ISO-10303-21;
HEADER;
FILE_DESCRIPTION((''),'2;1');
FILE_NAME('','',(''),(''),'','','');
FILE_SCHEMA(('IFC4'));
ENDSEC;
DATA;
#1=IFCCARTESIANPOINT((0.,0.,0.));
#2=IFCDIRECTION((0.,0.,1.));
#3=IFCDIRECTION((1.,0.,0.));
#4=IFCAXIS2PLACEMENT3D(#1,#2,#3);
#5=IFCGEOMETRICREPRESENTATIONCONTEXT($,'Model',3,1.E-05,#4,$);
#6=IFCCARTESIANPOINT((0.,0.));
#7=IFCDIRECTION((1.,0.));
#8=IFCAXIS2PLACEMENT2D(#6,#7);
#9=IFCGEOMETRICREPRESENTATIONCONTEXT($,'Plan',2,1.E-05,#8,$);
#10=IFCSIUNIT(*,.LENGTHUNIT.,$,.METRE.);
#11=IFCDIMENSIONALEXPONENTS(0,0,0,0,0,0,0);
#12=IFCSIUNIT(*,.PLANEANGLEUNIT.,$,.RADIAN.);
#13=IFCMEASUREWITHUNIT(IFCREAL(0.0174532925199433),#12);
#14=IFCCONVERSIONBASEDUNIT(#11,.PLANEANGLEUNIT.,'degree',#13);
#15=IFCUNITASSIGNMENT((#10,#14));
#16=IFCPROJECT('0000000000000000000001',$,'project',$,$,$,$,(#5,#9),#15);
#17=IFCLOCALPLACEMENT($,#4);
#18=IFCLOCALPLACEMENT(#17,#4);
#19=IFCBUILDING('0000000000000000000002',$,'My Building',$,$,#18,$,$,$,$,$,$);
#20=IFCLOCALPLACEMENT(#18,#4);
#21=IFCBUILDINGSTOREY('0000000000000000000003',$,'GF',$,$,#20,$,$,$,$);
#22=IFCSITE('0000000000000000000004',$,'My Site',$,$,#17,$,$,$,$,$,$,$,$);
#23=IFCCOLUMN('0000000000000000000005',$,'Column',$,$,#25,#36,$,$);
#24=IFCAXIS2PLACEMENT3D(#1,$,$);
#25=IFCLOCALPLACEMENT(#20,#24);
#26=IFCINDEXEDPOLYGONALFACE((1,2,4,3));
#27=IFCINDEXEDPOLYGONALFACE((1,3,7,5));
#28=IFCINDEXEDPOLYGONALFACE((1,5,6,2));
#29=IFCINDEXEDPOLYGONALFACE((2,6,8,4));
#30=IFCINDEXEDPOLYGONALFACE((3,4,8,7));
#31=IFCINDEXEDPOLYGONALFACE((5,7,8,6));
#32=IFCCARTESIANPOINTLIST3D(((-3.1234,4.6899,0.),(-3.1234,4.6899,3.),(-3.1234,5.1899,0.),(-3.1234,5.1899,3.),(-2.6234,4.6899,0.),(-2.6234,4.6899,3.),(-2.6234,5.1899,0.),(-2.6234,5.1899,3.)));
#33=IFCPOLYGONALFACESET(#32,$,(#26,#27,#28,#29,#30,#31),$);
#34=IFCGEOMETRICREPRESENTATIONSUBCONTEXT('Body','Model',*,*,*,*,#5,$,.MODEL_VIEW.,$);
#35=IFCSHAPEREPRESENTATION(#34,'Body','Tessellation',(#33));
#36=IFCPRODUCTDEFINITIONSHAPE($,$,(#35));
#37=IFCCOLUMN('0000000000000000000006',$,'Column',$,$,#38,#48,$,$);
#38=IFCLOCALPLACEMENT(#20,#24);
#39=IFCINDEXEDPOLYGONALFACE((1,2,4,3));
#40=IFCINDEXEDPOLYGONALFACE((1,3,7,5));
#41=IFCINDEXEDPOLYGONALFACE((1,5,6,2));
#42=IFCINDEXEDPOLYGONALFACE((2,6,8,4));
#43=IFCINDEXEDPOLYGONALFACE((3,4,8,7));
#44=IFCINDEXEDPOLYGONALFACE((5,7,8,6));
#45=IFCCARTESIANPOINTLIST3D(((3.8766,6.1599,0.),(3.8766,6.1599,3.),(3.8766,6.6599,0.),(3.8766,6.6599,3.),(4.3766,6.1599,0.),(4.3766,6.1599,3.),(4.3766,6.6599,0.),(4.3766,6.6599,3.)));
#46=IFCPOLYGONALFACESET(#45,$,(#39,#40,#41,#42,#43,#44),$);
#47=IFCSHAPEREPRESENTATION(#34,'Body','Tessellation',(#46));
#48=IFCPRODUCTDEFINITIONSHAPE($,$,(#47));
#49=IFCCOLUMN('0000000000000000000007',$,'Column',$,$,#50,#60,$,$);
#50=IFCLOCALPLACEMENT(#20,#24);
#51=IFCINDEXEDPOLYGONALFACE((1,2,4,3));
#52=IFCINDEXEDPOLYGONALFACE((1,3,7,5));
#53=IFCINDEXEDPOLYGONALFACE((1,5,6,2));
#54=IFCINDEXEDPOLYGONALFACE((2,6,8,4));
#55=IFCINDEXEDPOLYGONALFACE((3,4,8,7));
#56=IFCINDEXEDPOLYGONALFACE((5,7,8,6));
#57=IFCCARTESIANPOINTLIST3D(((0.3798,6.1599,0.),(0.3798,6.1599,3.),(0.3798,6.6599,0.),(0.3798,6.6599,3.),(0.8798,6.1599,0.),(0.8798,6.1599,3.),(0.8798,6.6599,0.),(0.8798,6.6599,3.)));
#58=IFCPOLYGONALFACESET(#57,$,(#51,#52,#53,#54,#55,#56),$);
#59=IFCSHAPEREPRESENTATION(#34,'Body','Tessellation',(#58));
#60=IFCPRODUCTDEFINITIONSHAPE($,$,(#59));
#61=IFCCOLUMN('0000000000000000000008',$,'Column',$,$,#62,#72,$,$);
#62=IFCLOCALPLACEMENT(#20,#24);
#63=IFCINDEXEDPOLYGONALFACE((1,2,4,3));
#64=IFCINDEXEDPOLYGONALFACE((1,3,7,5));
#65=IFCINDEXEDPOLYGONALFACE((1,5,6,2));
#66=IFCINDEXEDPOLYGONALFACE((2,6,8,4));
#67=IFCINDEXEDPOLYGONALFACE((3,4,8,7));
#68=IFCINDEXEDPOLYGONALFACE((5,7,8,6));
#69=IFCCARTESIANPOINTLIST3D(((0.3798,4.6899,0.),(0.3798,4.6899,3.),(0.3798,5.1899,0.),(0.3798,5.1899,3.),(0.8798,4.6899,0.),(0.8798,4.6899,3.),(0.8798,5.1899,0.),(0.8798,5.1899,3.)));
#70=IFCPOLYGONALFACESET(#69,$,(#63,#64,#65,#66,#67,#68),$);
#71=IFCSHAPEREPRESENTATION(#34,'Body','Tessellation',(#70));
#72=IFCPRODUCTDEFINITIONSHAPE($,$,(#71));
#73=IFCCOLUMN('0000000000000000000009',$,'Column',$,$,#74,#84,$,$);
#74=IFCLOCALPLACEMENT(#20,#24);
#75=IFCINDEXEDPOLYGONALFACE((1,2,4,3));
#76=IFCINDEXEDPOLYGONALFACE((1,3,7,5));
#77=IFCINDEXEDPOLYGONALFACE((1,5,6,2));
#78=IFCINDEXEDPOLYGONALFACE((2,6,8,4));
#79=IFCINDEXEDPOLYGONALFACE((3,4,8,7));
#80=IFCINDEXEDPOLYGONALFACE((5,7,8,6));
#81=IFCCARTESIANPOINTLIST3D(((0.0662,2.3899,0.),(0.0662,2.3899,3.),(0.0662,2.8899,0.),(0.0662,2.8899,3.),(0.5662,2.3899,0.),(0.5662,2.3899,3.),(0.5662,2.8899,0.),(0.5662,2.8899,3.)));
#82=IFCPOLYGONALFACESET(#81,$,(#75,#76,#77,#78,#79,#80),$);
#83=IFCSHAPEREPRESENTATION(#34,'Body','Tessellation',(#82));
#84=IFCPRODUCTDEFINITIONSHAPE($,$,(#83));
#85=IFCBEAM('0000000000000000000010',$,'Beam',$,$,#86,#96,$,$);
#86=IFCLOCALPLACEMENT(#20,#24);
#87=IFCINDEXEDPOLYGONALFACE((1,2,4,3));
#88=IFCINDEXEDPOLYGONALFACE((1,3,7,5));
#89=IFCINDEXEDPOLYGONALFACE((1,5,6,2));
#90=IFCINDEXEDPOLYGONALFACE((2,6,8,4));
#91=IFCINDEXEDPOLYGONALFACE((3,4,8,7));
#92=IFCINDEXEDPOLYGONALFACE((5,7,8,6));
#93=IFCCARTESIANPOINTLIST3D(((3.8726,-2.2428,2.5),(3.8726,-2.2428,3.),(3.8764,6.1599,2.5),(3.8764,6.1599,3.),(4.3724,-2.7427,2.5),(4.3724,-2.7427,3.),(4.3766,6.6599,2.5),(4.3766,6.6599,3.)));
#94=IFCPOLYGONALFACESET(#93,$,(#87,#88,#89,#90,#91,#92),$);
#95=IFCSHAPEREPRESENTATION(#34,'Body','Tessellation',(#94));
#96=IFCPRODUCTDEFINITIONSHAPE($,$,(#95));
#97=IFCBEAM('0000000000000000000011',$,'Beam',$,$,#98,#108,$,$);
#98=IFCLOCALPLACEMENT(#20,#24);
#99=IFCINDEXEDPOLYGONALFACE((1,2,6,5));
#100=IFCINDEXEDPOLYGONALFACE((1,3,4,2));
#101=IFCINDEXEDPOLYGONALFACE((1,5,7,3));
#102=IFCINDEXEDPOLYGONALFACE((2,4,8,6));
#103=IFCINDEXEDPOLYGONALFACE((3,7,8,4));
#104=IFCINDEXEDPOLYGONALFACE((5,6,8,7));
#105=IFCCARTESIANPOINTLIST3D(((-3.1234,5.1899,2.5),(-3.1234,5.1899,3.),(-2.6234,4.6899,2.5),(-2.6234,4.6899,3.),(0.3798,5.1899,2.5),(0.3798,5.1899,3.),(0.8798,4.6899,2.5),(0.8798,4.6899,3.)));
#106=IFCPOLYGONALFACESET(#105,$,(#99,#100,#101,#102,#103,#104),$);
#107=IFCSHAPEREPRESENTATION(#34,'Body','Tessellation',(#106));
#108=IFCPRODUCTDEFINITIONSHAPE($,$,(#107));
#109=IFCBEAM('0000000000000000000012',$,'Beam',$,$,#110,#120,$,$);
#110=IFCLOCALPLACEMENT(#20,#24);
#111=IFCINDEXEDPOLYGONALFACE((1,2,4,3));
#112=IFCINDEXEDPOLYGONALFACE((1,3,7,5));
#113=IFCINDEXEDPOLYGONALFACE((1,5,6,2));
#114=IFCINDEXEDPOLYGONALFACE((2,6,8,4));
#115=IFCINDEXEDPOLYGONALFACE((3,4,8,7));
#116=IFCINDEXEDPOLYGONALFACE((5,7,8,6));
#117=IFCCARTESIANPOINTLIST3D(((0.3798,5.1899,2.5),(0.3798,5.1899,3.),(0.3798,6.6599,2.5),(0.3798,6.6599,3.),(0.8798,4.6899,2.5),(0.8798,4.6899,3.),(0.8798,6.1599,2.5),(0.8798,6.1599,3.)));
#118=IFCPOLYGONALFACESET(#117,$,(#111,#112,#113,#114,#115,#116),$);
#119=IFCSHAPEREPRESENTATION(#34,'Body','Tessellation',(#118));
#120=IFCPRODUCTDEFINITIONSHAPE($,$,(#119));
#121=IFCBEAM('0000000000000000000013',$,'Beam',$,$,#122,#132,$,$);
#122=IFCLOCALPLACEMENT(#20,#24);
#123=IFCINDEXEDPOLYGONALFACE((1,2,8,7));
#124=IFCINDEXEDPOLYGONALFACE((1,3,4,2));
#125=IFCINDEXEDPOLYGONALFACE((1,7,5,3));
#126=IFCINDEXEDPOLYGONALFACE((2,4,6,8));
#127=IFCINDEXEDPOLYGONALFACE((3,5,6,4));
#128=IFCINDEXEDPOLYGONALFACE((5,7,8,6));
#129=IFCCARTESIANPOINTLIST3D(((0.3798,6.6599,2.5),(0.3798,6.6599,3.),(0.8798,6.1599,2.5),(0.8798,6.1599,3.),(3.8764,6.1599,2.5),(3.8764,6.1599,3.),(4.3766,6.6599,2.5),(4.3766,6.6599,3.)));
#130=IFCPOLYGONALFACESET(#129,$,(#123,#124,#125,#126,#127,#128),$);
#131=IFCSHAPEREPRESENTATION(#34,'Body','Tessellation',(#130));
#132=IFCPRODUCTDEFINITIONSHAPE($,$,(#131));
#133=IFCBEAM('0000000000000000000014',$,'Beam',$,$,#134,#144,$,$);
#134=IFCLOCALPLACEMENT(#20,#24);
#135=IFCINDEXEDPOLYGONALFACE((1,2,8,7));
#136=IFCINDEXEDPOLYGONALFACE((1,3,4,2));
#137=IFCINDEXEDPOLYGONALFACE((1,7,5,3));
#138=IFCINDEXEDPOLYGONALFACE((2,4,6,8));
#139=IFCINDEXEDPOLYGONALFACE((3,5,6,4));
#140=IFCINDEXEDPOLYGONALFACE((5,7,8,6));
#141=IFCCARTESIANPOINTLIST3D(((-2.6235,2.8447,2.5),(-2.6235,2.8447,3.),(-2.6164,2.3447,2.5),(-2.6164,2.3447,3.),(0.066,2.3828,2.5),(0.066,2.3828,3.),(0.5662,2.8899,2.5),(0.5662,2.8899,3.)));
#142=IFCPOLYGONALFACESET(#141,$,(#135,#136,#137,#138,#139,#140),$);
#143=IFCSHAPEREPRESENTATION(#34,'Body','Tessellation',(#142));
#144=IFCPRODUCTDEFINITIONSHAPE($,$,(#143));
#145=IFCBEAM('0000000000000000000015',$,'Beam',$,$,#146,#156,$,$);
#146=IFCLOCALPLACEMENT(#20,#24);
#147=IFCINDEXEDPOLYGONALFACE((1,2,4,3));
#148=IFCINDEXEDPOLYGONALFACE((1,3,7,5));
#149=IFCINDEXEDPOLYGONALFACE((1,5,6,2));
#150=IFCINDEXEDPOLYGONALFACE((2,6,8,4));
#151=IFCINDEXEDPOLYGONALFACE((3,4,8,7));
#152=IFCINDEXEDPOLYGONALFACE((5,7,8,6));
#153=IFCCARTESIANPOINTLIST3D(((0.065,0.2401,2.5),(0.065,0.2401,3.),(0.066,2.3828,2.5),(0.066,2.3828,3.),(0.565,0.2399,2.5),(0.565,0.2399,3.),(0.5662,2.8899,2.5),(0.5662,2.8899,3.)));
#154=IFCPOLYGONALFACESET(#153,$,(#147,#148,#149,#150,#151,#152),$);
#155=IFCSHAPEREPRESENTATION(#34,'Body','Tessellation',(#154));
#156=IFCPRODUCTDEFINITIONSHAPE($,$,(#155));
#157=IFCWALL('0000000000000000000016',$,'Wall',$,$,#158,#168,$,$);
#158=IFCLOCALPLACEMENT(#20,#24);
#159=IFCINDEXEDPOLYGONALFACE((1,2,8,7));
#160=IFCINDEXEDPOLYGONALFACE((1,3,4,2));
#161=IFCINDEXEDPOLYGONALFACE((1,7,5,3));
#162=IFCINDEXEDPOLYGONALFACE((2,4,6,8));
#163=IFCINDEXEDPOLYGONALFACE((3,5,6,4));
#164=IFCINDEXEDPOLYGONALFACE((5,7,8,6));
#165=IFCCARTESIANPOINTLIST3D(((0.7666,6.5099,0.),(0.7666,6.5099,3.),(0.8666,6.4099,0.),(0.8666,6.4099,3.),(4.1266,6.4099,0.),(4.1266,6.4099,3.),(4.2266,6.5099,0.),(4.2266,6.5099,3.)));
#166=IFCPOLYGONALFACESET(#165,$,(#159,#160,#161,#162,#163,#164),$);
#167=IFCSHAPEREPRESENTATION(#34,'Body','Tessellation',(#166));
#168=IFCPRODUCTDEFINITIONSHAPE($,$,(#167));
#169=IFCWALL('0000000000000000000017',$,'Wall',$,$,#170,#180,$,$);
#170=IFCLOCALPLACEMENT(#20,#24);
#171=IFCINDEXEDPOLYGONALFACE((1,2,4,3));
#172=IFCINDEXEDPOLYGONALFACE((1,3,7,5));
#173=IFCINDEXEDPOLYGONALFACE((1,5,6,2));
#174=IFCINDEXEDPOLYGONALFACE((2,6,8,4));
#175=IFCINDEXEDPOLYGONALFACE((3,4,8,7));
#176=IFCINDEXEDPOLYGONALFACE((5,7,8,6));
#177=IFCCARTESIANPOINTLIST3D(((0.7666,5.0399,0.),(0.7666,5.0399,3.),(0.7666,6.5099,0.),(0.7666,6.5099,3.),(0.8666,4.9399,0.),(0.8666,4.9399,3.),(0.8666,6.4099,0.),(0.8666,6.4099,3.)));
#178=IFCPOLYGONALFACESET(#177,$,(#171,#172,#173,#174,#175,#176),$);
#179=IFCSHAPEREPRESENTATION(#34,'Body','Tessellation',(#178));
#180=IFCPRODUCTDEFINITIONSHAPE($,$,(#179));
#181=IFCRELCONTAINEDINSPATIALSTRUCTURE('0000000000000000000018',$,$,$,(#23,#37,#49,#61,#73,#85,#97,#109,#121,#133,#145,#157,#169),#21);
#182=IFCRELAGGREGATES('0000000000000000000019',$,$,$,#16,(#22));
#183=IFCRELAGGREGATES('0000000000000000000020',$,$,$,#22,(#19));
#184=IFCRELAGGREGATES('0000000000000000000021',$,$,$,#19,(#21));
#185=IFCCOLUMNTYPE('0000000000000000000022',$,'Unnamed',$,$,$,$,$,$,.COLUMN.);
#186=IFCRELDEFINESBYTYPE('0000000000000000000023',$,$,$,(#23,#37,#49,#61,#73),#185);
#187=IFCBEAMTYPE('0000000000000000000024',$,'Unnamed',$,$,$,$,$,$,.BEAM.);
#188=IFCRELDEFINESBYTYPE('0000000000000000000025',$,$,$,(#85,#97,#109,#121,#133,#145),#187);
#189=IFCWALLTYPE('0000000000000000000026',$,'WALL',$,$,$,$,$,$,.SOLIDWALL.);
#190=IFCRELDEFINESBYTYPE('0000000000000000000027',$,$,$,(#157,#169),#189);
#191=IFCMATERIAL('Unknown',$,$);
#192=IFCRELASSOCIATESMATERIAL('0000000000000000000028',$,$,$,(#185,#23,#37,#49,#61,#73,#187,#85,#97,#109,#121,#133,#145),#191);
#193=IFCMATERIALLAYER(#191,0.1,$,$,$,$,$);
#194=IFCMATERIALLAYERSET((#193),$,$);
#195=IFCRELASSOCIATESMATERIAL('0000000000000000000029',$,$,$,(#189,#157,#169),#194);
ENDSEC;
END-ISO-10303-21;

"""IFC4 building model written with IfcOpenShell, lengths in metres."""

from ifc_helpers import new_model, entity, si_unit, converted_unit, frame, origin_with_axes, origin_2d_with_axis, place, context, subcontext, project, spatial, line, indexed_curve, rectangle, outline, extrude, clip, halfspace, material, layer, layer_set, layer_usage, material_profile, profile_set, profile_usage, type_object, element, save


model = new_model("IFC4")

# Units and contexts
model_context = context("Model", 3, precision=1e-05, world=origin_with_axes())
plan_context = context("Plan", 2, precision=1e-05, world=origin_2d_with_axis())
body_context_1 = subcontext(model_context, "Body", "Model", "MODEL_VIEW")
ifc_project = project(units=[si_unit("LENGTHUNIT", "METRE"), converted_unit("PLANEANGLEUNIT", "degree", entity("IfcReal", 0.0174532925199433), si_unit("PLANEANGLEUNIT", "RADIAN"), dimensions=[0, 0, 0, 0, 0, 0, 0])], contexts=[model_context, plan_context])

# Site, building, storey
site_placement = place(None, origin_with_axes())
site = spatial("IfcSite", under=ifc_project, at=site_placement, Name="My Site")
building_placement = place(site_placement, origin_with_axes())
building = spatial("IfcBuilding", under=site, at=building_placement, Name="My Building")
storey_placement = place(building_placement, origin_with_axes())
storey = spatial("IfcBuildingStorey", under=building, at=storey_placement, Name="GF")

# Columns
ifc_material = material(Name="Unknown")
ifc_material_profile_1 = material_profile(ifc_material, rectangle(XDim=0.5, YDim=0.5))
ifc_profile_set_1 = profile_set([ifc_material_profile_1])
ifc_profile_usage_1 = profile_usage(ifc_profile_set_1, cardinal=5)
column_type = type_object("IfcColumnType", Name="Unnamed", PredefinedType="COLUMN", material=ifc_profile_set_1)
column_1_placement = place(storey_placement, frame((-2.8734, 4.9399, 0.0), z_axis=(0.0, 0.0, 1.0), x_axis=(1.0, 0.0, 0.0)))
element("IfcColumn", 1, at=column_1_placement, inside=storey, type_object=column_type, material=ifc_profile_usage_1, Name="Column", context=body_context_1, shape_type="SweptSolid", body=[
    extrude(rectangle(XDim=0.5, YDim=0.5), origin_with_axes(), (0.0, 0.0, 1.0), 3.0),
])
ifc_profile_usage_2 = profile_usage(ifc_profile_set_1, cardinal=5)
column_2_placement = place(storey_placement, frame((4.1266, 6.4099, 0.0), z_axis=(0.0, 0.0, 1.0), x_axis=(1.0, 0.0, 0.0)))
element("IfcColumn", 2, at=column_2_placement, inside=storey, type_object=column_type, material=ifc_profile_usage_2, Name="Column", context=body_context_1, shape_type="SweptSolid", body=[
    extrude(rectangle(XDim=0.5, YDim=0.5), origin_with_axes(), (0.0, 0.0, 1.0), 3.0),
])
ifc_profile_usage_3 = profile_usage(ifc_profile_set_1, cardinal=5)
column_3_placement = place(storey_placement, frame((0.6298, 6.4099, 0.0), z_axis=(0.0, 0.0, 1.0), x_axis=(1.0, 0.0, 0.0)))
element("IfcColumn", 3, at=column_3_placement, inside=storey, type_object=column_type, material=ifc_profile_usage_3, Name="Column", context=body_context_1, shape_type="SweptSolid", body=[
    extrude(rectangle(XDim=0.5, YDim=0.5), origin_with_axes(), (0.0, 0.0, 1.0), 3.0),
])
ifc_profile_usage_4 = profile_usage(ifc_profile_set_1, cardinal=5)
column_4_placement = place(storey_placement, frame((0.6298, 4.9399, 0.0), z_axis=(0.0, 0.0, 1.0), x_axis=(1.0, 0.0, 0.0)))
element("IfcColumn", 4, at=column_4_placement, inside=storey, type_object=column_type, material=ifc_profile_usage_4, Name="Column", context=body_context_1, shape_type="SweptSolid", body=[
    extrude(rectangle(XDim=0.5, YDim=0.5), origin_with_axes(), (0.0, 0.0, 1.0), 3.0),
])
ifc_profile_usage_5 = profile_usage(ifc_profile_set_1, cardinal=5)
column_5_placement = place(storey_placement, frame((0.3162, 2.6399, 0.0), z_axis=(0.0, 0.0, 1.0), x_axis=(1.0, 0.0, 0.0)))
element("IfcColumn", 5, at=column_5_placement, inside=storey, type_object=column_type, material=ifc_profile_usage_5, Name="Column", context=body_context_1, shape_type="SweptSolid", body=[
    extrude(rectangle(XDim=0.5, YDim=0.5), origin_with_axes(), (0.0, 0.0, 1.0), 3.0),
])

# Beams
ifc_material_profile_2 = material_profile(ifc_material, rectangle(XDim=0.5, YDim=0.5))
ifc_profile_set_2 = profile_set([ifc_material_profile_2])
ifc_profile_usage_6 = profile_usage(ifc_profile_set_2, cardinal=7)
beam_type = type_object("IfcBeamType", Name="Unnamed", PredefinedType="BEAM", material=ifc_profile_set_2)
beam_1_placement = place(storey_placement, frame((4.3768, 7.1599, 3.0), z_axis=(-0.000445, -1.0, 0.0), x_axis=(1.0, -0.000445, 0.0)))
element("IfcBeam", 6, at=beam_1_placement, inside=storey, type_object=beam_type, material=ifc_profile_usage_6, Name="Beam", context=body_context_1, shape_type="Clipping", body=[
    clip(clip(extrude(rectangle(XDim=0.5, YDim=0.5), frame((-0.25, -0.25, 0.0), z_axis=(0.0, 0.0, 1.0), x_axis=(1.0, 0.0, 0.0)), (0.0, 0.0, 1.0), 10.4026), halfspace(frame((0.0, -3.0, 9.9026), z_axis=(-0.706868, 0.0, 0.707345), x_axis=(0.0, 1.0, 0.0)), False)), halfspace(frame((0.0, -3.0, 0.5), z_axis=(-0.707264, 0.0, -0.706949), x_axis=(0.0, 1.0, 0.0)), False)),
])
ifc_profile_usage_7 = profile_usage(ifc_profile_set_2, cardinal=7)
beam_2_placement = place(storey_placement, frame((-3.1234, 5.1899, 3.0), z_axis=(1.0, 0.0, 0.0), x_axis=(0.0, 1.0, 0.0)))
element("IfcBeam", 7, at=beam_2_placement, inside=storey, type_object=beam_type, material=ifc_profile_usage_7, Name="Beam", context=body_context_1, shape_type="Clipping", body=[
    clip(clip(extrude(rectangle(XDim=0.5, YDim=0.5), frame((-0.25, -0.25, 0.0), z_axis=(0.0, 0.0, 1.0), x_axis=(1.0, 0.0, 0.0)), (0.0, 0.0, 1.0), 4.0032), halfspace(frame((-0.5, -3.0, 4.0032), z_axis=(0.707107, 0.0, 0.707107), x_axis=(0.0, -1.0, 0.0)), False)), halfspace(frame((0.0, -3.0, 0.0), z_axis=(-0.707107, 0.0, -0.707106), x_axis=(0.0, 1.0, 0.0)), False)),
])
ifc_profile_usage_8 = profile_usage(ifc_profile_set_2, cardinal=7)
beam_3_placement = place(storey_placement, frame((0.3798, 4.6899, 3.0), z_axis=(0.0, 1.0, 0.0), x_axis=(-1.0, 0.0, 0.0)))
element("IfcBeam", 8, at=beam_3_placement, inside=storey, type_object=beam_type, material=ifc_profile_usage_8, Name="Beam", context=body_context_1, shape_type="Clipping", body=[
    clip(clip(extrude(rectangle(XDim=0.5, YDim=0.5), frame((-0.25, -0.25, 0.0), z_axis=(0.0, 0.0, 1.0), x_axis=(1.0, 0.0, 0.0)), (0.0, 0.0, 1.0), 1.97), halfspace(frame((0.0, -3.0, 1.97), z_axis=(-0.707107, 0.0, 0.707107), x_axis=(0.0, 1.0, 0.0)), False)), halfspace(frame((-0.5, -3.0, 0.0), z_axis=(0.707107, 0.0, -0.707106), x_axis=(0.0, -1.0, 0.0)), False)),
])
ifc_profile_usage_9 = profile_usage(ifc_profile_set_2, cardinal=7)
beam_4_placement = place(storey_placement, frame((0.3798, 6.6599, 3.0), z_axis=(1.0, 0.0, 0.0), x_axis=(0.0, 1.0, 0.0)))
element("IfcBeam", 9, at=beam_4_placement, inside=storey, type_object=beam_type, material=ifc_profile_usage_9, Name="Beam", context=body_context_1, shape_type="Clipping", body=[
    clip(clip(extrude(rectangle(XDim=0.5, YDim=0.5), frame((-0.25, -0.25, 0.0), z_axis=(0.0, 0.0, 1.0), x_axis=(1.0, 0.0, 0.0)), (0.0, 0.0, 1.0), 4.4968), halfspace(frame((0.0, -3.0, 3.9968), z_axis=(-0.707264, 0.0, 0.70695), x_axis=(0.0, 1.0, 0.0)), False)), halfspace(frame((0.0, -3.0, 0.0), z_axis=(-0.707107, 0.0, -0.707107), x_axis=(0.0, 1.0, 0.0)), False)),
])
ifc_profile_usage_10 = profile_usage(ifc_profile_set_2, cardinal=7)
beam_5_placement = place(storey_placement, frame((-2.6235, 2.8447, 3.0), z_axis=(0.9999, 0.014175, 0.0), x_axis=(-0.014175, 0.9999, 0.0)))
element("IfcBeam", 10, at=beam_5_placement, inside=storey, type_object=beam_type, material=ifc_profile_usage_10, Name="Beam", context=body_context_1, shape_type="Clipping", body=[
    clip(extrude(rectangle(XDim=0.5, YDim=0.5), frame((-0.25, -0.25, 0.0), z_axis=(0.0, 0.0, 1.0), x_axis=(1.0, 0.0, 0.0)), (0.0, 0.0, 1.0), 3.69), halfspace(frame((0.0, -3.0, 3.19), z_axis=(-0.712265, 0.0, 0.701911), x_axis=(0.0, 1.0, 0.0)), False)),
])
ifc_profile_usage_11 = profile_usage(ifc_profile_set_2, cardinal=7)
beam_6_placement = place(storey_placement, frame((0.5664, 3.3899, 3.0), z_axis=(-0.000466, -1.0, 0.0), x_axis=(1.0, -0.000466, 0.0)))
element("IfcBeam", 11, at=beam_6_placement, inside=storey, type_object=beam_type, material=ifc_profile_usage_11, Name="Beam", context=body_context_1, shape_type="Clipping", body=[
    clip(extrude(rectangle(XDim=0.5, YDim=0.5), frame((-0.25, -0.25, 0.0), z_axis=(0.0, 0.0, 1.0), x_axis=(1.0, 0.0, 0.0)), (0.0, 0.0, 1.0), 3.15), halfspace(frame((0.0, -3.0, 0.5), z_axis=(-0.712264, 0.0, -0.701911), x_axis=(0.0, 1.0, 0.0)), False)),
])

# Walls
ifc_layer = layer(ifc_material, 0.1)
ifc_layer_set = layer_set([ifc_layer])
ifc_layer_usage_1 = layer_usage(ifc_layer_set, "AXIS2", "POSITIVE", 0.0)
wall_type = type_object("IfcWallType", Name="WALL", PredefinedType="SOLIDWALL", material=ifc_layer_set)
wall_1_placement = place(storey_placement, frame((4.2266, 6.5099, 0.0), z_axis=(0.0, 0.0, 1.0), x_axis=(-1.0, 0.0, 0.0)))
element("IfcWall", 12, at=wall_1_placement, inside=storey, type_object=wall_type, material=ifc_layer_usage_1, Name="Wall", context=body_context_1, shape_type="SweptSolid", body=[
    extrude(outline(indexed_curve([(0.0, 0.0), (0.1, 0.1), (3.36, 0.1), (3.46, 0.0)], segments=[line(1, 2, 3, 4, 1)])), origin_with_axes(), (0.0, 0.0, 1.0), 3.0),
])
ifc_layer_usage_2 = layer_usage(ifc_layer_set, "AXIS2", "POSITIVE", 0.0)
wall_2_placement = place(storey_placement, frame((0.7666, 6.5099, 0.0), z_axis=(0.0, 0.0, 1.0), x_axis=(0.0, -1.0, 0.0)))
element("IfcWall", 13, at=wall_2_placement, inside=storey, type_object=wall_type, material=ifc_layer_usage_2, Name="Wall", context=body_context_1, shape_type="SweptSolid", body=[
    extrude(outline(indexed_curve([(0.0, 0.0), (0.1, 0.1), (1.57, 0.1), (1.47, 0.0)], segments=[line(1, 2, 3, 4, 1)])), origin_with_axes(), (0.0, 0.0, 1.0), 3.0),
])

save(model, "model.ifc")
